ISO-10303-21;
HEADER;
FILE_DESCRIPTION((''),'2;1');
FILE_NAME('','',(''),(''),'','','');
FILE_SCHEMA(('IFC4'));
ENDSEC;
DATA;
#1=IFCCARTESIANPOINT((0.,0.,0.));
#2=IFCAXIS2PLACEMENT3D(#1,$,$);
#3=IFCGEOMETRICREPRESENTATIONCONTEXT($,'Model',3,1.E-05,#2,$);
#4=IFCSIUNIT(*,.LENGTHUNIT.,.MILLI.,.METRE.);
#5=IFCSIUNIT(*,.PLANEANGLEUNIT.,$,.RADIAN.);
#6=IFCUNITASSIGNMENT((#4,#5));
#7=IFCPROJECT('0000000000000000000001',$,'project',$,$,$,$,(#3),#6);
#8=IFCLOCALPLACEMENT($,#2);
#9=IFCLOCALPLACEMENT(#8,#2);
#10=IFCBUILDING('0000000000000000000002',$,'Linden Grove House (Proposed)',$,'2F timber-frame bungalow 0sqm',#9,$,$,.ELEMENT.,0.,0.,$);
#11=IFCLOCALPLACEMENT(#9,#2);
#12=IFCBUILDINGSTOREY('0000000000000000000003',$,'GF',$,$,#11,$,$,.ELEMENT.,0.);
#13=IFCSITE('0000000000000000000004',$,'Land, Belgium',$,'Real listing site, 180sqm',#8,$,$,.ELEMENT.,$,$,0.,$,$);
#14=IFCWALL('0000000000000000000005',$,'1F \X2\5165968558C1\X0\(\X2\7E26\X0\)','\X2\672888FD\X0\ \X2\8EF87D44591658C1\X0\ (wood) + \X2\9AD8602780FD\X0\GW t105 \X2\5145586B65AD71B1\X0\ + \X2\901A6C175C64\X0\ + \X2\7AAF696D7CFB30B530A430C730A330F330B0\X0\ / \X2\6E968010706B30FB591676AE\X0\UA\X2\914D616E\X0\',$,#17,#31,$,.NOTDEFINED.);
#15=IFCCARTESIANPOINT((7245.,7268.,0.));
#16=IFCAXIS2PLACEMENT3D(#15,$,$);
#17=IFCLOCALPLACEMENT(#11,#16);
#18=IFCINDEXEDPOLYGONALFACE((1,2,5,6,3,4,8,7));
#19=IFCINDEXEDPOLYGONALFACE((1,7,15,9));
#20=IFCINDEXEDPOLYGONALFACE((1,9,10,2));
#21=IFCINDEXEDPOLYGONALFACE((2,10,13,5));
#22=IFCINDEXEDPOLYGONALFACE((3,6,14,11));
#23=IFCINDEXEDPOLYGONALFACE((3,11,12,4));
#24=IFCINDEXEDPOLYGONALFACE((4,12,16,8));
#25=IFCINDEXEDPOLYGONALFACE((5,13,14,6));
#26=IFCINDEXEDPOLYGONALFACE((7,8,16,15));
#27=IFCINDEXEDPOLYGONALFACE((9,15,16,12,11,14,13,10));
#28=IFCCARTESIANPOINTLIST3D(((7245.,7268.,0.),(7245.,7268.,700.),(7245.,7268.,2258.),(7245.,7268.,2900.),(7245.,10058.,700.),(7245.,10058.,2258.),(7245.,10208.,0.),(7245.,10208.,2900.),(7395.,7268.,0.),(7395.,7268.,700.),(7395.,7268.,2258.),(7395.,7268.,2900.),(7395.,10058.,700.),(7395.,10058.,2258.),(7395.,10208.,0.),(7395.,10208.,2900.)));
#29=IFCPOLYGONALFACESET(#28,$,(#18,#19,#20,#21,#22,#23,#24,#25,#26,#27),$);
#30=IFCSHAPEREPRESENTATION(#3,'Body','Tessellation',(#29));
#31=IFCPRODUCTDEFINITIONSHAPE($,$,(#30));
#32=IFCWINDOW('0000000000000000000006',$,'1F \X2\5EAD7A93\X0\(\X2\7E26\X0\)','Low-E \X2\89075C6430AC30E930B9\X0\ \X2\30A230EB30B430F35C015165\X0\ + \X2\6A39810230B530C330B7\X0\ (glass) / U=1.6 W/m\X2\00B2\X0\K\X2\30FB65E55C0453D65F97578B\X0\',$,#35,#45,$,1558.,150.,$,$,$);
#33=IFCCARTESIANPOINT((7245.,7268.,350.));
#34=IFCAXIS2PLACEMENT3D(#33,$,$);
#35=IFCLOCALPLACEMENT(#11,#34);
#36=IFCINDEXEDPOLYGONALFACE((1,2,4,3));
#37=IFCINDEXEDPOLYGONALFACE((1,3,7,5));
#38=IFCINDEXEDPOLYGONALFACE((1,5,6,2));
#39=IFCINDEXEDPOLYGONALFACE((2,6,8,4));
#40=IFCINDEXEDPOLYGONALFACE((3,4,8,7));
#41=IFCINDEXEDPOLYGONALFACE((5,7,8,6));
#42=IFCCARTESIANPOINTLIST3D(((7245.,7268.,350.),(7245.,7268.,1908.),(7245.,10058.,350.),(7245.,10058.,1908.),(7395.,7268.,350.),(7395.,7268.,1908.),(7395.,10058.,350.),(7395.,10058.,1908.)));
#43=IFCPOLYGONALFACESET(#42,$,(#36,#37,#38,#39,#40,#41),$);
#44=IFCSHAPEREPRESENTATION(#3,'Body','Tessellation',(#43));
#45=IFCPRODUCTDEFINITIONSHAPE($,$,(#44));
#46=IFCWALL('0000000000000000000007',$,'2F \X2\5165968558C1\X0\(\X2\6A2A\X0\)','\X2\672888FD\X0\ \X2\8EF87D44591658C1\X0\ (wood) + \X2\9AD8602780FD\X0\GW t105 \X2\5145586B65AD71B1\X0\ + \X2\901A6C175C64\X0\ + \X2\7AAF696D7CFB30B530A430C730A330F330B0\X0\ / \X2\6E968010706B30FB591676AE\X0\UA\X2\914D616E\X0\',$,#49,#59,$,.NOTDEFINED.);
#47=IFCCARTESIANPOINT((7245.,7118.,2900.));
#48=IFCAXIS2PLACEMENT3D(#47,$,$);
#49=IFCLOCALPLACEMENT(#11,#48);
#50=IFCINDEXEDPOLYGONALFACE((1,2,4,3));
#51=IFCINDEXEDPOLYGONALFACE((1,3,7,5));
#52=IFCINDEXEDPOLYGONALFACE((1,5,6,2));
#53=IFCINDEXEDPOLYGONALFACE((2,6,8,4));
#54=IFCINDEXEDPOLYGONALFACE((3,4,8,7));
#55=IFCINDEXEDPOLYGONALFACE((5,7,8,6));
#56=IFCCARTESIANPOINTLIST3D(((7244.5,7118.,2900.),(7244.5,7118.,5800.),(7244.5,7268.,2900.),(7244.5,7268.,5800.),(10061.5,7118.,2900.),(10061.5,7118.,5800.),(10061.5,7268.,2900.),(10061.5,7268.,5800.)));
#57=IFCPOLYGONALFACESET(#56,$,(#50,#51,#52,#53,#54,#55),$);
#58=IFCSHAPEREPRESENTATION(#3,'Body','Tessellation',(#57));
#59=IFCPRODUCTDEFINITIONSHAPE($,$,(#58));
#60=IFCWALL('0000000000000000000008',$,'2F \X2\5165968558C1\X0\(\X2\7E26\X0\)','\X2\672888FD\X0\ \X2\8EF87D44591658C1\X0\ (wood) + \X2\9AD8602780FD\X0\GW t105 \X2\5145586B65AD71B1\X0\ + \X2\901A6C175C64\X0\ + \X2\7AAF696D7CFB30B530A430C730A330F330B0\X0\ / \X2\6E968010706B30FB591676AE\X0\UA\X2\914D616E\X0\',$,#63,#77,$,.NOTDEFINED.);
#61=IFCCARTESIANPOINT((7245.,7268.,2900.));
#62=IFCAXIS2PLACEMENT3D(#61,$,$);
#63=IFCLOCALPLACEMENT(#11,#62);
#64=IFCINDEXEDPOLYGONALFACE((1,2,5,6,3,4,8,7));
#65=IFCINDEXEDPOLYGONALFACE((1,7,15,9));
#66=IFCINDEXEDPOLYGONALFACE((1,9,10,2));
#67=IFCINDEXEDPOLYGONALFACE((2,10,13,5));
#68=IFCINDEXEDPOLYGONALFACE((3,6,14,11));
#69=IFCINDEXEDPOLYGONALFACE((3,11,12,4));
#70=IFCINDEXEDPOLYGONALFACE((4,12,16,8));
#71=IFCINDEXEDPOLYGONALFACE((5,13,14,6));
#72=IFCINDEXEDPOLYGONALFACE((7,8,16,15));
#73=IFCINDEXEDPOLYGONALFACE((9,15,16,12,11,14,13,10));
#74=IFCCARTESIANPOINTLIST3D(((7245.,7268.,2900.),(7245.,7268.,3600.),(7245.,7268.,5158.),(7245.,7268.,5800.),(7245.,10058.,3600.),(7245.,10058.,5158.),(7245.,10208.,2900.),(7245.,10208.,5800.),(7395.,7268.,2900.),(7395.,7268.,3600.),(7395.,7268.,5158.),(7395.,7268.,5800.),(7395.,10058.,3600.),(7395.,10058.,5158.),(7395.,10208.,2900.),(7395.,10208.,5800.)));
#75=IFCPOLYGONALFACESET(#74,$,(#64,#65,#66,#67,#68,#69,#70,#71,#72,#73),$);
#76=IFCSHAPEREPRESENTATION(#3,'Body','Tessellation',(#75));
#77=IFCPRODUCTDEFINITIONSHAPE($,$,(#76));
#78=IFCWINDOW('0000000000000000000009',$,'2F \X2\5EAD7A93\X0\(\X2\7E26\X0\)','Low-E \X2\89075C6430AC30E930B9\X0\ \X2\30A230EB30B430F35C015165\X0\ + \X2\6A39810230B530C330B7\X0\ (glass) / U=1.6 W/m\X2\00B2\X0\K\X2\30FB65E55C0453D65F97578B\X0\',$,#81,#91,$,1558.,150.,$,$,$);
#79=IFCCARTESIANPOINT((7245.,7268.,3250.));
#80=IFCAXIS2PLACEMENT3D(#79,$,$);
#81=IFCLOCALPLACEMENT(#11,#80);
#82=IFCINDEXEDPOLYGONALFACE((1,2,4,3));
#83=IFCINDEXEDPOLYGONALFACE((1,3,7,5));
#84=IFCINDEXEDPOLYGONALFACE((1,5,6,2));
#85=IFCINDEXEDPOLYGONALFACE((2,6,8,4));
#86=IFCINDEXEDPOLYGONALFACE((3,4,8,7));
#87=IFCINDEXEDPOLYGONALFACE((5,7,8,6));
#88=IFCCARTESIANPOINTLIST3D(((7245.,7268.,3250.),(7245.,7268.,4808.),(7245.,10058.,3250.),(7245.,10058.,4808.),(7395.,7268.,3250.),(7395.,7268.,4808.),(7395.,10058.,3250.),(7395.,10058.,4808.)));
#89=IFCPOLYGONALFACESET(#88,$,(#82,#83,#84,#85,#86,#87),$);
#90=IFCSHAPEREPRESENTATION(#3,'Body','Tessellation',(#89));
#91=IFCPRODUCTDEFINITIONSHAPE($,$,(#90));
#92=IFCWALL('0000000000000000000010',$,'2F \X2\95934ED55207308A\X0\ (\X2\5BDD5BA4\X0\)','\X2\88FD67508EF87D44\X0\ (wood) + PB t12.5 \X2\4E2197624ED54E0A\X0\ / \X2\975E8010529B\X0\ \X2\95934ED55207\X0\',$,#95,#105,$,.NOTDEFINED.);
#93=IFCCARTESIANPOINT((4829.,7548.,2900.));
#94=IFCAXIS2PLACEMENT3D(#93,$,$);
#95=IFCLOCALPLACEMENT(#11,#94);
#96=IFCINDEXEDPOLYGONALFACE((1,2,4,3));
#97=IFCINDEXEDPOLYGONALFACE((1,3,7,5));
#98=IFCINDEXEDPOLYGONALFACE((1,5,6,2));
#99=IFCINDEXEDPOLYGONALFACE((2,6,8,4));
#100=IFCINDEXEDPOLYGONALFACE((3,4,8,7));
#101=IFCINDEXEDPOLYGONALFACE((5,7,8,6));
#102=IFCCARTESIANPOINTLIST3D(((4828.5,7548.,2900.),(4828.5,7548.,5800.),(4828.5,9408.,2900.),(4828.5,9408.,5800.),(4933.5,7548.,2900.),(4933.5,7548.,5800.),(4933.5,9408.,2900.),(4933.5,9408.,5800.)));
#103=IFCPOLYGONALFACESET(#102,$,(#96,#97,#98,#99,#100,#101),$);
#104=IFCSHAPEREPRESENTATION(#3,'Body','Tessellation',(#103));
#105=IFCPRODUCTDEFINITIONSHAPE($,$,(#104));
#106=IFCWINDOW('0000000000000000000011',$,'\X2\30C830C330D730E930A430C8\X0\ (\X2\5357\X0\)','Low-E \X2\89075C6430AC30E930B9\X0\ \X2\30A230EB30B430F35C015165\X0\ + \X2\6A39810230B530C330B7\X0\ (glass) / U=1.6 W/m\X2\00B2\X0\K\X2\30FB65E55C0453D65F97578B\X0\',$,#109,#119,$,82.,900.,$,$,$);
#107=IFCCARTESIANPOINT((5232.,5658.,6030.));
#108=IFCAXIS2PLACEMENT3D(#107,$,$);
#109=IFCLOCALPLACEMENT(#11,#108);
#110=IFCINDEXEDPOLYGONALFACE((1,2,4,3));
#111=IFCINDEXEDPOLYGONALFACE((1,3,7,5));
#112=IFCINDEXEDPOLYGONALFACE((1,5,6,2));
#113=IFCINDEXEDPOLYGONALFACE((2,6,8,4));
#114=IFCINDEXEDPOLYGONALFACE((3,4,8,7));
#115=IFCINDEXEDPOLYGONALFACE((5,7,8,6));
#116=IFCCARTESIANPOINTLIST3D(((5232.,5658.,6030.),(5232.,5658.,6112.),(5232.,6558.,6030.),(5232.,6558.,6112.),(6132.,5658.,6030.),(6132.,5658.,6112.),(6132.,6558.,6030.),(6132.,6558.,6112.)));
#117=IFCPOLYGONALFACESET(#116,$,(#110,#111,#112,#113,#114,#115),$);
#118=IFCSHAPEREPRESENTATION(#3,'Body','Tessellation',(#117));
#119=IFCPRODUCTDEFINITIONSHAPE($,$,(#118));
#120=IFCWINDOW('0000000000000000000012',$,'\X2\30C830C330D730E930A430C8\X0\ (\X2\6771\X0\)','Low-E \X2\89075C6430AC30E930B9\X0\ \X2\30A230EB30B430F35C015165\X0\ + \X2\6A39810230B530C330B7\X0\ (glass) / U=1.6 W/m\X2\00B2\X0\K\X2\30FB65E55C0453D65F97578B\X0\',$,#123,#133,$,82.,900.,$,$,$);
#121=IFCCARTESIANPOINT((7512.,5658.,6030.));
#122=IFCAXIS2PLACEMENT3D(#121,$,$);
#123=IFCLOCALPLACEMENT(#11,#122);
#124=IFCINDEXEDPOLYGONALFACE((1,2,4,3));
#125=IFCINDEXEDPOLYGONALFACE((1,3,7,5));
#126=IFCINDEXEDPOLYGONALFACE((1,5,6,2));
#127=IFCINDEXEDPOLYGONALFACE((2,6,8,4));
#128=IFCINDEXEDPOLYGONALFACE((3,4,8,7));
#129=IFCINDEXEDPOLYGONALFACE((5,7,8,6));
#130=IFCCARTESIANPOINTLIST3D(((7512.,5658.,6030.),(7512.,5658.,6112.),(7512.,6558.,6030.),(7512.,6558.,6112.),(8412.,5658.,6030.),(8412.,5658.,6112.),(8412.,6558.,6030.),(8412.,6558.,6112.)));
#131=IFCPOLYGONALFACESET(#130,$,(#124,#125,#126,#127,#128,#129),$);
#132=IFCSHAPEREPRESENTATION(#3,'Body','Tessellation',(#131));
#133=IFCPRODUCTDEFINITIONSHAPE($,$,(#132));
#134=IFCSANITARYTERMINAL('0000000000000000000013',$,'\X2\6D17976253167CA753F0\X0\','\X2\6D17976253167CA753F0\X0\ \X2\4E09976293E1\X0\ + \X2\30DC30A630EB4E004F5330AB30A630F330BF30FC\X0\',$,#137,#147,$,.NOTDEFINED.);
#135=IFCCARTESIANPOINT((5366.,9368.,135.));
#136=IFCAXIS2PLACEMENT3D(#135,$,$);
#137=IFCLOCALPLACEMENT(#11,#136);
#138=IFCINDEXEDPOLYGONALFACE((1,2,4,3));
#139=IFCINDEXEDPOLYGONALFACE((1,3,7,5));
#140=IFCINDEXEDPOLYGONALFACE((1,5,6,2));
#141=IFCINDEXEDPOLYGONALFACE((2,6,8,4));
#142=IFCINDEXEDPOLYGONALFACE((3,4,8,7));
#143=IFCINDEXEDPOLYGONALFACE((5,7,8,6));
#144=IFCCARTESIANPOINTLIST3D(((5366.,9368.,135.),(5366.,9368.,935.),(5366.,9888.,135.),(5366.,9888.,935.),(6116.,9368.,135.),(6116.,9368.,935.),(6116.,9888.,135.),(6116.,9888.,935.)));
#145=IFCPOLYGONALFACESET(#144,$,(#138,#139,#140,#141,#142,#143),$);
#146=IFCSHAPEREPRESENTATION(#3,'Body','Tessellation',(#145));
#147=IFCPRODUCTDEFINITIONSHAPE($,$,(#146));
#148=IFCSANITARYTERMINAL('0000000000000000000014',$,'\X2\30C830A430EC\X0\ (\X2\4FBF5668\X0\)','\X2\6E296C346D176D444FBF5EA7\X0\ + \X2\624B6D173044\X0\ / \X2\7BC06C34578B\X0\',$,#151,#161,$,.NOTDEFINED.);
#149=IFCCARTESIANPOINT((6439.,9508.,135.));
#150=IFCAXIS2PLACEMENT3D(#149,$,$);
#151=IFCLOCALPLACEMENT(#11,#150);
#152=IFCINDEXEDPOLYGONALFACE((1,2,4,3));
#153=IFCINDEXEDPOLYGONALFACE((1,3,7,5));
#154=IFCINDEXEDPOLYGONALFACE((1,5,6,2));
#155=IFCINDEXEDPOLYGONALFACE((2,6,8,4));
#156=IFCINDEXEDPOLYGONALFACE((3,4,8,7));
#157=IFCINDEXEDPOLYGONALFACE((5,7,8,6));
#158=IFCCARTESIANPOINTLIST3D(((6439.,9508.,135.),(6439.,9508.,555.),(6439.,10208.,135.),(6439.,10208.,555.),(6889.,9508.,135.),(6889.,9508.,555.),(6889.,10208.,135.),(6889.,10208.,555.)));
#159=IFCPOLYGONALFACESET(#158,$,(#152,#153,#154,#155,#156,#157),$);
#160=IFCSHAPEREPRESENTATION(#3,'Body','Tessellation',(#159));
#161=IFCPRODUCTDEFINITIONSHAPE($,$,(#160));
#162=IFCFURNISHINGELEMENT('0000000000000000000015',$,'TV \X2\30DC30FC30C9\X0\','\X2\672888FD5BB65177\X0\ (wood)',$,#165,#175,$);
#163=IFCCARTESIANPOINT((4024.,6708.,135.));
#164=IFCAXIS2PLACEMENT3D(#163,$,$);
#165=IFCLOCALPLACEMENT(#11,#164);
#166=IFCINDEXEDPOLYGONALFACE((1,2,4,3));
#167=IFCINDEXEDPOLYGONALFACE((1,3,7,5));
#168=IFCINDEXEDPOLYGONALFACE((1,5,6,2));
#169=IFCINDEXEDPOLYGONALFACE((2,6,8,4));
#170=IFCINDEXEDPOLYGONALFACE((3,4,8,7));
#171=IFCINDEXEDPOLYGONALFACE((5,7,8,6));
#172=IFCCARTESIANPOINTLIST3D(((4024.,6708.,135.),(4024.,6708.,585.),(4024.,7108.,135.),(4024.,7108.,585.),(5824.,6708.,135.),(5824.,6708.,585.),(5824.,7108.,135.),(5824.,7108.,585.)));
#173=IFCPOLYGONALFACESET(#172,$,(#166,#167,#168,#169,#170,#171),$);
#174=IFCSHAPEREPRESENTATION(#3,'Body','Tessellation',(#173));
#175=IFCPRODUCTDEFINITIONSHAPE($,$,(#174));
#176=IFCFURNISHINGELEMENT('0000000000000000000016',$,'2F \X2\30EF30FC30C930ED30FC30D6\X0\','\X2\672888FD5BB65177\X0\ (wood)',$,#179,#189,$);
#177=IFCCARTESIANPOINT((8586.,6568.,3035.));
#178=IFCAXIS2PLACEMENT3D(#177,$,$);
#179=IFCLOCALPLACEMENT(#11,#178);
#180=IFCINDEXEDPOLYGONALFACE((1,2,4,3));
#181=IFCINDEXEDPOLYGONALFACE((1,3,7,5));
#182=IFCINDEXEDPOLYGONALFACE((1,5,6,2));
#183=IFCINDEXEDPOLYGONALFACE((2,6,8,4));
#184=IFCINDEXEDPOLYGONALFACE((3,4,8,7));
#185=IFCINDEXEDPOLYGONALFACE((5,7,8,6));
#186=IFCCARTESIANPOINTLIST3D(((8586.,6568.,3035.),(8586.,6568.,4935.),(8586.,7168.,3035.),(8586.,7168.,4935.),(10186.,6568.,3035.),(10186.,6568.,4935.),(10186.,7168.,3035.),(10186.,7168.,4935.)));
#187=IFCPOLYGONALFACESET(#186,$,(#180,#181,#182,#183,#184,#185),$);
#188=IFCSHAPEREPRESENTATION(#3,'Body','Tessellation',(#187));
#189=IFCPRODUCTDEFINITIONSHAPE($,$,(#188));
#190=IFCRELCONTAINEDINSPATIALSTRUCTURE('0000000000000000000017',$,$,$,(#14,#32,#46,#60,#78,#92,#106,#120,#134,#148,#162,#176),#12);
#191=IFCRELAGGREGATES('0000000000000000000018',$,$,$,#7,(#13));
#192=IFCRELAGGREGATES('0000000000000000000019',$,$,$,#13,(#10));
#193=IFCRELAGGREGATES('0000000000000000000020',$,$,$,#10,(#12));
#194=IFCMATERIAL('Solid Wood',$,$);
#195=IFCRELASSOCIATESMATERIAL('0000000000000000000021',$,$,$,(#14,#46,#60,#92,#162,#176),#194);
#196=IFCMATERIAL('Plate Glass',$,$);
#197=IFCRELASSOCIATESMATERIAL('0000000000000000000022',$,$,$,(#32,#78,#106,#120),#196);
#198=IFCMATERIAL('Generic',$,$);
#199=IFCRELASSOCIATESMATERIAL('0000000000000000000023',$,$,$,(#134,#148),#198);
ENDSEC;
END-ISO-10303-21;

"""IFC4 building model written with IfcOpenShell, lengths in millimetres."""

from ifc_helpers import new_model, si_unit, frame, frame_2d, origin, place, context, project, spatial, rectangle, extrude, material, element, fill, save


model = new_model("IFC4")

# Units and contexts
model_context = context("Model", 3, precision=1e-05, world=origin())
ifc_project = project(units=[si_unit("LENGTHUNIT", "METRE", prefix="MILLI"), si_unit("PLANEANGLEUNIT", "RADIAN")], contexts=[model_context])

# Site, building, storey
site_placement = place(None, origin())
site = spatial("IfcSite", under=ifc_project, at=site_placement, Name="Land, Belgium", ObjectType="Real listing site, 180sqm", CompositionType="ELEMENT", RefElevation=0.0)
building_placement = place(site_placement, origin())
building = spatial("IfcBuilding", under=site, at=building_placement, Name="Linden Grove House (Proposed)", ObjectType="2F timber-frame bungalow 0sqm", CompositionType="ELEMENT", ElevationOfRefHeight=0.0, ElevationOfTerrain=0.0)
storey_placement = place(building_placement, origin())
storey = spatial("IfcBuildingStorey", under=building, at=storey_placement, Name="GF", CompositionType="ELEMENT", Elevation=0.0)

# Shared definitions
ifc_material_1 = material(Name="Solid Wood")

# Wall, opening, window
wall_1_placement = place(storey_placement, frame((7245.0, 7268.0, 0.0)))
wall_1 = element("IfcWall", 1, at=wall_1_placement, inside=storey, material=ifc_material_1, Name="1F 入隅壁(縦)", Description="木製 軸組外壁 (wood) + 高性能GW t105 充填断熱 + 通気層 + 窯業系サイディング / 準耐火・外皮UA配慮", PredefinedType="NOTDEFINED", context=model_context, shape_type="SweptSolid", body=[
    extrude(rectangle(XDim=150.0, YDim=2940.0, at=frame_2d((75.0, 1470.0))), frame((7245.0, 7268.0, 0.0)), (0.0, 0.0, 1.0), 2900.0),
])
opening_1_placement = place(storey_placement, frame((7245.0, 7268.0, 350.0)))
opening_1 = element("IfcOpeningElement", 2, at=opening_1_placement, cuts=wall_1, PredefinedType="NOTDEFINED", context=model_context, shape_type="SweptSolid", body=[
    extrude(rectangle(XDim=150.0, YDim=2790.0, at=frame_2d((75.0, 1395.0))), frame((7245.0, 7268.0, 350.0)), (0.0, 0.0, 1.0), 1558.0),
])
ifc_material_2 = material(Name="Plate Glass")
window_1_placement = place(storey_placement, frame((7245.0, 7268.0, 350.0)))
window_1 = element("IfcWindow", 3, at=window_1_placement, inside=storey, material=ifc_material_2, Name="1F 庭窓(縦)", Description="Low-E 複層ガラス アルゴン封入 + 樹脂サッシ (glass) / U=1.6 W/m²K・日射取得型", OverallHeight=1558.0, OverallWidth=150.0, context=model_context, shape_type="SweptSolid", body=[
    extrude(rectangle(XDim=150.0, YDim=2790.0, at=frame_2d((75.0, 1395.0))), frame((7245.0, 7268.0, 350.0)), (0.0, 0.0, 1.0), 1558.0),
])
fill(opening_1, window_1)

# Wall
wall_2_placement = place(storey_placement, frame((7245.0, 7118.0, 2900.0)))
element("IfcWall", 4, at=wall_2_placement, inside=storey, material=ifc_material_1, Name="2F 入隅壁(横)", Description="木製 軸組外壁 (wood) + 高性能GW t105 充填断熱 + 通気層 + 窯業系サイディング / 準耐火・外皮UA配慮", PredefinedType="NOTDEFINED", context=model_context, shape_type="SweptSolid", body=[
    extrude(rectangle(XDim=2817.0, YDim=150.0, at=frame_2d((1408.0, 75.0))), frame((7245.0, 7118.0, 2900.0)), (0.0, 0.0, 1.0), 2900.0),
])

# Wall, opening, window
wall_3_placement = place(storey_placement, frame((7245.0, 7268.0, 2900.0)))
wall_3 = element("IfcWall", 5, at=wall_3_placement, inside=storey, material=ifc_material_1, Name="2F 入隅壁(縦)", Description="木製 軸組外壁 (wood) + 高性能GW t105 充填断熱 + 通気層 + 窯業系サイディング / 準耐火・外皮UA配慮", PredefinedType="NOTDEFINED", context=model_context, shape_type="SweptSolid", body=[
    extrude(rectangle(XDim=150.0, YDim=2940.0, at=frame_2d((75.0, 1470.0))), frame((7245.0, 7268.0, 2900.0)), (0.0, 0.0, 1.0), 2900.0),
])
opening_2_placement = place(storey_placement, frame((7245.0, 7268.0, 3250.0)))
opening_2 = element("IfcOpeningElement", 6, at=opening_2_placement, cuts=wall_3, PredefinedType="NOTDEFINED", context=model_context, shape_type="SweptSolid", body=[
    extrude(rectangle(XDim=150.0, YDim=2790.0, at=frame_2d((75.0, 1395.0))), frame((7245.0, 7268.0, 3250.0)), (0.0, 0.0, 1.0), 1558.0),
])
window_2_placement = place(storey_placement, frame((7245.0, 7268.0, 3250.0)))
window_2 = element("IfcWindow", 7, at=window_2_placement, inside=storey, material=ifc_material_2, Name="2F 庭窓(縦)", Description="Low-E 複層ガラス アルゴン封入 + 樹脂サッシ (glass) / U=1.6 W/m²K・日射取得型", OverallHeight=1558.0, OverallWidth=150.0, context=model_context, shape_type="SweptSolid", body=[
    extrude(rectangle(XDim=150.0, YDim=2790.0, at=frame_2d((75.0, 1395.0))), frame((7245.0, 7268.0, 3250.0)), (0.0, 0.0, 1.0), 1558.0),
])
fill(opening_2, window_2)

# Wall
wall_4_placement = place(storey_placement, frame((4829.0, 7548.0, 2900.0)))
element("IfcWall", 8, at=wall_4_placement, inside=storey, material=ifc_material_1, Name="2F 間仕切り (寝室)", Description="製材軸組 (wood) + PB t12.5 両面仕上 / 非耐力 間仕切", PredefinedType="NOTDEFINED", context=model_context, shape_type="SweptSolid", body=[
    extrude(rectangle(XDim=105.0, YDim=1860.0, at=frame_2d((52.0, 930.0))), frame((4829.0, 7548.0, 2900.0)), (0.0, 0.0, 1.0), 2900.0),
])

# Windows
window_3_placement = place(storey_placement, frame((5232.0, 5658.0, 6030.0)))
element("IfcWindow", 9, at=window_3_placement, inside=storey, material=ifc_material_2, Name="トップライト (南)", Description="Low-E 複層ガラス アルゴン封入 + 樹脂サッシ (glass) / U=1.6 W/m²K・日射取得型", OverallHeight=82.0, OverallWidth=900.0, context=model_context, shape_type="SweptSolid", body=[
    extrude(rectangle(XDim=900.0, YDim=900.0, at=frame_2d((450.0, 450.0))), frame((5232.0, 5658.0, 6030.0)), (0.0, 0.0, 1.0), 82.0),
])
window_4_placement = place(storey_placement, frame((7512.0, 5658.0, 6030.0)))
element("IfcWindow", 10, at=window_4_placement, inside=storey, material=ifc_material_2, Name="トップライト (東)", Description="Low-E 複層ガラス アルゴン封入 + 樹脂サッシ (glass) / U=1.6 W/m²K・日射取得型", OverallHeight=82.0, OverallWidth=900.0, context=model_context, shape_type="SweptSolid", body=[
    extrude(rectangle(XDim=900.0, YDim=900.0, at=frame_2d((450.0, 450.0))), frame((7512.0, 5658.0, 6030.0)), (0.0, 0.0, 1.0), 82.0),
])

# Sanitary terminals
ifc_material_3 = material(Name="Generic")
sanitary_terminal_1_placement = place(storey_placement, frame((5366.0, 9368.0, 135.0)))
element("IfcSanitaryTerminal", 11, at=sanitary_terminal_1_placement, inside=storey, material=ifc_material_3, Name="洗面化粧台", Description="洗面化粧台 三面鏡 + ボウル一体カウンター", PredefinedType="NOTDEFINED", context=model_context, shape_type="SweptSolid", body=[
    extrude(rectangle(XDim=750.0, YDim=520.0, at=frame_2d((375.0, 260.0))), frame((5366.0, 9368.0, 135.0)), (0.0, 0.0, 1.0), 800.0),
])
sanitary_terminal_2_placement = place(storey_placement, frame((6439.0, 9508.0, 135.0)))
element("IfcSanitaryTerminal", 12, at=sanitary_terminal_2_placement, inside=storey, material=ifc_material_3, Name="トイレ (便器)", Description="温水洗浄便座 + 手洗い / 節水型", PredefinedType="NOTDEFINED", context=model_context, shape_type="SweptSolid", body=[
    extrude(rectangle(XDim=450.0, YDim=700.0, at=frame_2d((225.0, 350.0))), frame((6439.0, 9508.0, 135.0)), (0.0, 0.0, 1.0), 420.0),
])

# Furnishing elements
furnishing_1_placement = place(storey_placement, frame((4024.0, 6708.0, 135.0)))
element("IfcFurnishingElement", 13, at=furnishing_1_placement, inside=storey, material=ifc_material_1, Name="TV ボード", Description="木製家具 (wood)", context=model_context, shape_type="SweptSolid", body=[
    extrude(rectangle(XDim=1800.0, YDim=400.0, at=frame_2d((900.0, 200.0))), frame((4024.0, 6708.0, 135.0)), (0.0, 0.0, 1.0), 450.0),
])
furnishing_2_placement = place(storey_placement, frame((8586.0, 6568.0, 3035.0)))
element("IfcFurnishingElement", 14, at=furnishing_2_placement, inside=storey, material=ifc_material_1, Name="2F ワードローブ", Description="木製家具 (wood)", context=model_context, shape_type="SweptSolid", body=[
    extrude(rectangle(XDim=1600.0, YDim=600.0, at=frame_2d((800.0, 300.0))), frame((8586.0, 6568.0, 3035.0)), (0.0, 0.0, 1.0), 1900.0),
])

save(model, "model.ifc")
